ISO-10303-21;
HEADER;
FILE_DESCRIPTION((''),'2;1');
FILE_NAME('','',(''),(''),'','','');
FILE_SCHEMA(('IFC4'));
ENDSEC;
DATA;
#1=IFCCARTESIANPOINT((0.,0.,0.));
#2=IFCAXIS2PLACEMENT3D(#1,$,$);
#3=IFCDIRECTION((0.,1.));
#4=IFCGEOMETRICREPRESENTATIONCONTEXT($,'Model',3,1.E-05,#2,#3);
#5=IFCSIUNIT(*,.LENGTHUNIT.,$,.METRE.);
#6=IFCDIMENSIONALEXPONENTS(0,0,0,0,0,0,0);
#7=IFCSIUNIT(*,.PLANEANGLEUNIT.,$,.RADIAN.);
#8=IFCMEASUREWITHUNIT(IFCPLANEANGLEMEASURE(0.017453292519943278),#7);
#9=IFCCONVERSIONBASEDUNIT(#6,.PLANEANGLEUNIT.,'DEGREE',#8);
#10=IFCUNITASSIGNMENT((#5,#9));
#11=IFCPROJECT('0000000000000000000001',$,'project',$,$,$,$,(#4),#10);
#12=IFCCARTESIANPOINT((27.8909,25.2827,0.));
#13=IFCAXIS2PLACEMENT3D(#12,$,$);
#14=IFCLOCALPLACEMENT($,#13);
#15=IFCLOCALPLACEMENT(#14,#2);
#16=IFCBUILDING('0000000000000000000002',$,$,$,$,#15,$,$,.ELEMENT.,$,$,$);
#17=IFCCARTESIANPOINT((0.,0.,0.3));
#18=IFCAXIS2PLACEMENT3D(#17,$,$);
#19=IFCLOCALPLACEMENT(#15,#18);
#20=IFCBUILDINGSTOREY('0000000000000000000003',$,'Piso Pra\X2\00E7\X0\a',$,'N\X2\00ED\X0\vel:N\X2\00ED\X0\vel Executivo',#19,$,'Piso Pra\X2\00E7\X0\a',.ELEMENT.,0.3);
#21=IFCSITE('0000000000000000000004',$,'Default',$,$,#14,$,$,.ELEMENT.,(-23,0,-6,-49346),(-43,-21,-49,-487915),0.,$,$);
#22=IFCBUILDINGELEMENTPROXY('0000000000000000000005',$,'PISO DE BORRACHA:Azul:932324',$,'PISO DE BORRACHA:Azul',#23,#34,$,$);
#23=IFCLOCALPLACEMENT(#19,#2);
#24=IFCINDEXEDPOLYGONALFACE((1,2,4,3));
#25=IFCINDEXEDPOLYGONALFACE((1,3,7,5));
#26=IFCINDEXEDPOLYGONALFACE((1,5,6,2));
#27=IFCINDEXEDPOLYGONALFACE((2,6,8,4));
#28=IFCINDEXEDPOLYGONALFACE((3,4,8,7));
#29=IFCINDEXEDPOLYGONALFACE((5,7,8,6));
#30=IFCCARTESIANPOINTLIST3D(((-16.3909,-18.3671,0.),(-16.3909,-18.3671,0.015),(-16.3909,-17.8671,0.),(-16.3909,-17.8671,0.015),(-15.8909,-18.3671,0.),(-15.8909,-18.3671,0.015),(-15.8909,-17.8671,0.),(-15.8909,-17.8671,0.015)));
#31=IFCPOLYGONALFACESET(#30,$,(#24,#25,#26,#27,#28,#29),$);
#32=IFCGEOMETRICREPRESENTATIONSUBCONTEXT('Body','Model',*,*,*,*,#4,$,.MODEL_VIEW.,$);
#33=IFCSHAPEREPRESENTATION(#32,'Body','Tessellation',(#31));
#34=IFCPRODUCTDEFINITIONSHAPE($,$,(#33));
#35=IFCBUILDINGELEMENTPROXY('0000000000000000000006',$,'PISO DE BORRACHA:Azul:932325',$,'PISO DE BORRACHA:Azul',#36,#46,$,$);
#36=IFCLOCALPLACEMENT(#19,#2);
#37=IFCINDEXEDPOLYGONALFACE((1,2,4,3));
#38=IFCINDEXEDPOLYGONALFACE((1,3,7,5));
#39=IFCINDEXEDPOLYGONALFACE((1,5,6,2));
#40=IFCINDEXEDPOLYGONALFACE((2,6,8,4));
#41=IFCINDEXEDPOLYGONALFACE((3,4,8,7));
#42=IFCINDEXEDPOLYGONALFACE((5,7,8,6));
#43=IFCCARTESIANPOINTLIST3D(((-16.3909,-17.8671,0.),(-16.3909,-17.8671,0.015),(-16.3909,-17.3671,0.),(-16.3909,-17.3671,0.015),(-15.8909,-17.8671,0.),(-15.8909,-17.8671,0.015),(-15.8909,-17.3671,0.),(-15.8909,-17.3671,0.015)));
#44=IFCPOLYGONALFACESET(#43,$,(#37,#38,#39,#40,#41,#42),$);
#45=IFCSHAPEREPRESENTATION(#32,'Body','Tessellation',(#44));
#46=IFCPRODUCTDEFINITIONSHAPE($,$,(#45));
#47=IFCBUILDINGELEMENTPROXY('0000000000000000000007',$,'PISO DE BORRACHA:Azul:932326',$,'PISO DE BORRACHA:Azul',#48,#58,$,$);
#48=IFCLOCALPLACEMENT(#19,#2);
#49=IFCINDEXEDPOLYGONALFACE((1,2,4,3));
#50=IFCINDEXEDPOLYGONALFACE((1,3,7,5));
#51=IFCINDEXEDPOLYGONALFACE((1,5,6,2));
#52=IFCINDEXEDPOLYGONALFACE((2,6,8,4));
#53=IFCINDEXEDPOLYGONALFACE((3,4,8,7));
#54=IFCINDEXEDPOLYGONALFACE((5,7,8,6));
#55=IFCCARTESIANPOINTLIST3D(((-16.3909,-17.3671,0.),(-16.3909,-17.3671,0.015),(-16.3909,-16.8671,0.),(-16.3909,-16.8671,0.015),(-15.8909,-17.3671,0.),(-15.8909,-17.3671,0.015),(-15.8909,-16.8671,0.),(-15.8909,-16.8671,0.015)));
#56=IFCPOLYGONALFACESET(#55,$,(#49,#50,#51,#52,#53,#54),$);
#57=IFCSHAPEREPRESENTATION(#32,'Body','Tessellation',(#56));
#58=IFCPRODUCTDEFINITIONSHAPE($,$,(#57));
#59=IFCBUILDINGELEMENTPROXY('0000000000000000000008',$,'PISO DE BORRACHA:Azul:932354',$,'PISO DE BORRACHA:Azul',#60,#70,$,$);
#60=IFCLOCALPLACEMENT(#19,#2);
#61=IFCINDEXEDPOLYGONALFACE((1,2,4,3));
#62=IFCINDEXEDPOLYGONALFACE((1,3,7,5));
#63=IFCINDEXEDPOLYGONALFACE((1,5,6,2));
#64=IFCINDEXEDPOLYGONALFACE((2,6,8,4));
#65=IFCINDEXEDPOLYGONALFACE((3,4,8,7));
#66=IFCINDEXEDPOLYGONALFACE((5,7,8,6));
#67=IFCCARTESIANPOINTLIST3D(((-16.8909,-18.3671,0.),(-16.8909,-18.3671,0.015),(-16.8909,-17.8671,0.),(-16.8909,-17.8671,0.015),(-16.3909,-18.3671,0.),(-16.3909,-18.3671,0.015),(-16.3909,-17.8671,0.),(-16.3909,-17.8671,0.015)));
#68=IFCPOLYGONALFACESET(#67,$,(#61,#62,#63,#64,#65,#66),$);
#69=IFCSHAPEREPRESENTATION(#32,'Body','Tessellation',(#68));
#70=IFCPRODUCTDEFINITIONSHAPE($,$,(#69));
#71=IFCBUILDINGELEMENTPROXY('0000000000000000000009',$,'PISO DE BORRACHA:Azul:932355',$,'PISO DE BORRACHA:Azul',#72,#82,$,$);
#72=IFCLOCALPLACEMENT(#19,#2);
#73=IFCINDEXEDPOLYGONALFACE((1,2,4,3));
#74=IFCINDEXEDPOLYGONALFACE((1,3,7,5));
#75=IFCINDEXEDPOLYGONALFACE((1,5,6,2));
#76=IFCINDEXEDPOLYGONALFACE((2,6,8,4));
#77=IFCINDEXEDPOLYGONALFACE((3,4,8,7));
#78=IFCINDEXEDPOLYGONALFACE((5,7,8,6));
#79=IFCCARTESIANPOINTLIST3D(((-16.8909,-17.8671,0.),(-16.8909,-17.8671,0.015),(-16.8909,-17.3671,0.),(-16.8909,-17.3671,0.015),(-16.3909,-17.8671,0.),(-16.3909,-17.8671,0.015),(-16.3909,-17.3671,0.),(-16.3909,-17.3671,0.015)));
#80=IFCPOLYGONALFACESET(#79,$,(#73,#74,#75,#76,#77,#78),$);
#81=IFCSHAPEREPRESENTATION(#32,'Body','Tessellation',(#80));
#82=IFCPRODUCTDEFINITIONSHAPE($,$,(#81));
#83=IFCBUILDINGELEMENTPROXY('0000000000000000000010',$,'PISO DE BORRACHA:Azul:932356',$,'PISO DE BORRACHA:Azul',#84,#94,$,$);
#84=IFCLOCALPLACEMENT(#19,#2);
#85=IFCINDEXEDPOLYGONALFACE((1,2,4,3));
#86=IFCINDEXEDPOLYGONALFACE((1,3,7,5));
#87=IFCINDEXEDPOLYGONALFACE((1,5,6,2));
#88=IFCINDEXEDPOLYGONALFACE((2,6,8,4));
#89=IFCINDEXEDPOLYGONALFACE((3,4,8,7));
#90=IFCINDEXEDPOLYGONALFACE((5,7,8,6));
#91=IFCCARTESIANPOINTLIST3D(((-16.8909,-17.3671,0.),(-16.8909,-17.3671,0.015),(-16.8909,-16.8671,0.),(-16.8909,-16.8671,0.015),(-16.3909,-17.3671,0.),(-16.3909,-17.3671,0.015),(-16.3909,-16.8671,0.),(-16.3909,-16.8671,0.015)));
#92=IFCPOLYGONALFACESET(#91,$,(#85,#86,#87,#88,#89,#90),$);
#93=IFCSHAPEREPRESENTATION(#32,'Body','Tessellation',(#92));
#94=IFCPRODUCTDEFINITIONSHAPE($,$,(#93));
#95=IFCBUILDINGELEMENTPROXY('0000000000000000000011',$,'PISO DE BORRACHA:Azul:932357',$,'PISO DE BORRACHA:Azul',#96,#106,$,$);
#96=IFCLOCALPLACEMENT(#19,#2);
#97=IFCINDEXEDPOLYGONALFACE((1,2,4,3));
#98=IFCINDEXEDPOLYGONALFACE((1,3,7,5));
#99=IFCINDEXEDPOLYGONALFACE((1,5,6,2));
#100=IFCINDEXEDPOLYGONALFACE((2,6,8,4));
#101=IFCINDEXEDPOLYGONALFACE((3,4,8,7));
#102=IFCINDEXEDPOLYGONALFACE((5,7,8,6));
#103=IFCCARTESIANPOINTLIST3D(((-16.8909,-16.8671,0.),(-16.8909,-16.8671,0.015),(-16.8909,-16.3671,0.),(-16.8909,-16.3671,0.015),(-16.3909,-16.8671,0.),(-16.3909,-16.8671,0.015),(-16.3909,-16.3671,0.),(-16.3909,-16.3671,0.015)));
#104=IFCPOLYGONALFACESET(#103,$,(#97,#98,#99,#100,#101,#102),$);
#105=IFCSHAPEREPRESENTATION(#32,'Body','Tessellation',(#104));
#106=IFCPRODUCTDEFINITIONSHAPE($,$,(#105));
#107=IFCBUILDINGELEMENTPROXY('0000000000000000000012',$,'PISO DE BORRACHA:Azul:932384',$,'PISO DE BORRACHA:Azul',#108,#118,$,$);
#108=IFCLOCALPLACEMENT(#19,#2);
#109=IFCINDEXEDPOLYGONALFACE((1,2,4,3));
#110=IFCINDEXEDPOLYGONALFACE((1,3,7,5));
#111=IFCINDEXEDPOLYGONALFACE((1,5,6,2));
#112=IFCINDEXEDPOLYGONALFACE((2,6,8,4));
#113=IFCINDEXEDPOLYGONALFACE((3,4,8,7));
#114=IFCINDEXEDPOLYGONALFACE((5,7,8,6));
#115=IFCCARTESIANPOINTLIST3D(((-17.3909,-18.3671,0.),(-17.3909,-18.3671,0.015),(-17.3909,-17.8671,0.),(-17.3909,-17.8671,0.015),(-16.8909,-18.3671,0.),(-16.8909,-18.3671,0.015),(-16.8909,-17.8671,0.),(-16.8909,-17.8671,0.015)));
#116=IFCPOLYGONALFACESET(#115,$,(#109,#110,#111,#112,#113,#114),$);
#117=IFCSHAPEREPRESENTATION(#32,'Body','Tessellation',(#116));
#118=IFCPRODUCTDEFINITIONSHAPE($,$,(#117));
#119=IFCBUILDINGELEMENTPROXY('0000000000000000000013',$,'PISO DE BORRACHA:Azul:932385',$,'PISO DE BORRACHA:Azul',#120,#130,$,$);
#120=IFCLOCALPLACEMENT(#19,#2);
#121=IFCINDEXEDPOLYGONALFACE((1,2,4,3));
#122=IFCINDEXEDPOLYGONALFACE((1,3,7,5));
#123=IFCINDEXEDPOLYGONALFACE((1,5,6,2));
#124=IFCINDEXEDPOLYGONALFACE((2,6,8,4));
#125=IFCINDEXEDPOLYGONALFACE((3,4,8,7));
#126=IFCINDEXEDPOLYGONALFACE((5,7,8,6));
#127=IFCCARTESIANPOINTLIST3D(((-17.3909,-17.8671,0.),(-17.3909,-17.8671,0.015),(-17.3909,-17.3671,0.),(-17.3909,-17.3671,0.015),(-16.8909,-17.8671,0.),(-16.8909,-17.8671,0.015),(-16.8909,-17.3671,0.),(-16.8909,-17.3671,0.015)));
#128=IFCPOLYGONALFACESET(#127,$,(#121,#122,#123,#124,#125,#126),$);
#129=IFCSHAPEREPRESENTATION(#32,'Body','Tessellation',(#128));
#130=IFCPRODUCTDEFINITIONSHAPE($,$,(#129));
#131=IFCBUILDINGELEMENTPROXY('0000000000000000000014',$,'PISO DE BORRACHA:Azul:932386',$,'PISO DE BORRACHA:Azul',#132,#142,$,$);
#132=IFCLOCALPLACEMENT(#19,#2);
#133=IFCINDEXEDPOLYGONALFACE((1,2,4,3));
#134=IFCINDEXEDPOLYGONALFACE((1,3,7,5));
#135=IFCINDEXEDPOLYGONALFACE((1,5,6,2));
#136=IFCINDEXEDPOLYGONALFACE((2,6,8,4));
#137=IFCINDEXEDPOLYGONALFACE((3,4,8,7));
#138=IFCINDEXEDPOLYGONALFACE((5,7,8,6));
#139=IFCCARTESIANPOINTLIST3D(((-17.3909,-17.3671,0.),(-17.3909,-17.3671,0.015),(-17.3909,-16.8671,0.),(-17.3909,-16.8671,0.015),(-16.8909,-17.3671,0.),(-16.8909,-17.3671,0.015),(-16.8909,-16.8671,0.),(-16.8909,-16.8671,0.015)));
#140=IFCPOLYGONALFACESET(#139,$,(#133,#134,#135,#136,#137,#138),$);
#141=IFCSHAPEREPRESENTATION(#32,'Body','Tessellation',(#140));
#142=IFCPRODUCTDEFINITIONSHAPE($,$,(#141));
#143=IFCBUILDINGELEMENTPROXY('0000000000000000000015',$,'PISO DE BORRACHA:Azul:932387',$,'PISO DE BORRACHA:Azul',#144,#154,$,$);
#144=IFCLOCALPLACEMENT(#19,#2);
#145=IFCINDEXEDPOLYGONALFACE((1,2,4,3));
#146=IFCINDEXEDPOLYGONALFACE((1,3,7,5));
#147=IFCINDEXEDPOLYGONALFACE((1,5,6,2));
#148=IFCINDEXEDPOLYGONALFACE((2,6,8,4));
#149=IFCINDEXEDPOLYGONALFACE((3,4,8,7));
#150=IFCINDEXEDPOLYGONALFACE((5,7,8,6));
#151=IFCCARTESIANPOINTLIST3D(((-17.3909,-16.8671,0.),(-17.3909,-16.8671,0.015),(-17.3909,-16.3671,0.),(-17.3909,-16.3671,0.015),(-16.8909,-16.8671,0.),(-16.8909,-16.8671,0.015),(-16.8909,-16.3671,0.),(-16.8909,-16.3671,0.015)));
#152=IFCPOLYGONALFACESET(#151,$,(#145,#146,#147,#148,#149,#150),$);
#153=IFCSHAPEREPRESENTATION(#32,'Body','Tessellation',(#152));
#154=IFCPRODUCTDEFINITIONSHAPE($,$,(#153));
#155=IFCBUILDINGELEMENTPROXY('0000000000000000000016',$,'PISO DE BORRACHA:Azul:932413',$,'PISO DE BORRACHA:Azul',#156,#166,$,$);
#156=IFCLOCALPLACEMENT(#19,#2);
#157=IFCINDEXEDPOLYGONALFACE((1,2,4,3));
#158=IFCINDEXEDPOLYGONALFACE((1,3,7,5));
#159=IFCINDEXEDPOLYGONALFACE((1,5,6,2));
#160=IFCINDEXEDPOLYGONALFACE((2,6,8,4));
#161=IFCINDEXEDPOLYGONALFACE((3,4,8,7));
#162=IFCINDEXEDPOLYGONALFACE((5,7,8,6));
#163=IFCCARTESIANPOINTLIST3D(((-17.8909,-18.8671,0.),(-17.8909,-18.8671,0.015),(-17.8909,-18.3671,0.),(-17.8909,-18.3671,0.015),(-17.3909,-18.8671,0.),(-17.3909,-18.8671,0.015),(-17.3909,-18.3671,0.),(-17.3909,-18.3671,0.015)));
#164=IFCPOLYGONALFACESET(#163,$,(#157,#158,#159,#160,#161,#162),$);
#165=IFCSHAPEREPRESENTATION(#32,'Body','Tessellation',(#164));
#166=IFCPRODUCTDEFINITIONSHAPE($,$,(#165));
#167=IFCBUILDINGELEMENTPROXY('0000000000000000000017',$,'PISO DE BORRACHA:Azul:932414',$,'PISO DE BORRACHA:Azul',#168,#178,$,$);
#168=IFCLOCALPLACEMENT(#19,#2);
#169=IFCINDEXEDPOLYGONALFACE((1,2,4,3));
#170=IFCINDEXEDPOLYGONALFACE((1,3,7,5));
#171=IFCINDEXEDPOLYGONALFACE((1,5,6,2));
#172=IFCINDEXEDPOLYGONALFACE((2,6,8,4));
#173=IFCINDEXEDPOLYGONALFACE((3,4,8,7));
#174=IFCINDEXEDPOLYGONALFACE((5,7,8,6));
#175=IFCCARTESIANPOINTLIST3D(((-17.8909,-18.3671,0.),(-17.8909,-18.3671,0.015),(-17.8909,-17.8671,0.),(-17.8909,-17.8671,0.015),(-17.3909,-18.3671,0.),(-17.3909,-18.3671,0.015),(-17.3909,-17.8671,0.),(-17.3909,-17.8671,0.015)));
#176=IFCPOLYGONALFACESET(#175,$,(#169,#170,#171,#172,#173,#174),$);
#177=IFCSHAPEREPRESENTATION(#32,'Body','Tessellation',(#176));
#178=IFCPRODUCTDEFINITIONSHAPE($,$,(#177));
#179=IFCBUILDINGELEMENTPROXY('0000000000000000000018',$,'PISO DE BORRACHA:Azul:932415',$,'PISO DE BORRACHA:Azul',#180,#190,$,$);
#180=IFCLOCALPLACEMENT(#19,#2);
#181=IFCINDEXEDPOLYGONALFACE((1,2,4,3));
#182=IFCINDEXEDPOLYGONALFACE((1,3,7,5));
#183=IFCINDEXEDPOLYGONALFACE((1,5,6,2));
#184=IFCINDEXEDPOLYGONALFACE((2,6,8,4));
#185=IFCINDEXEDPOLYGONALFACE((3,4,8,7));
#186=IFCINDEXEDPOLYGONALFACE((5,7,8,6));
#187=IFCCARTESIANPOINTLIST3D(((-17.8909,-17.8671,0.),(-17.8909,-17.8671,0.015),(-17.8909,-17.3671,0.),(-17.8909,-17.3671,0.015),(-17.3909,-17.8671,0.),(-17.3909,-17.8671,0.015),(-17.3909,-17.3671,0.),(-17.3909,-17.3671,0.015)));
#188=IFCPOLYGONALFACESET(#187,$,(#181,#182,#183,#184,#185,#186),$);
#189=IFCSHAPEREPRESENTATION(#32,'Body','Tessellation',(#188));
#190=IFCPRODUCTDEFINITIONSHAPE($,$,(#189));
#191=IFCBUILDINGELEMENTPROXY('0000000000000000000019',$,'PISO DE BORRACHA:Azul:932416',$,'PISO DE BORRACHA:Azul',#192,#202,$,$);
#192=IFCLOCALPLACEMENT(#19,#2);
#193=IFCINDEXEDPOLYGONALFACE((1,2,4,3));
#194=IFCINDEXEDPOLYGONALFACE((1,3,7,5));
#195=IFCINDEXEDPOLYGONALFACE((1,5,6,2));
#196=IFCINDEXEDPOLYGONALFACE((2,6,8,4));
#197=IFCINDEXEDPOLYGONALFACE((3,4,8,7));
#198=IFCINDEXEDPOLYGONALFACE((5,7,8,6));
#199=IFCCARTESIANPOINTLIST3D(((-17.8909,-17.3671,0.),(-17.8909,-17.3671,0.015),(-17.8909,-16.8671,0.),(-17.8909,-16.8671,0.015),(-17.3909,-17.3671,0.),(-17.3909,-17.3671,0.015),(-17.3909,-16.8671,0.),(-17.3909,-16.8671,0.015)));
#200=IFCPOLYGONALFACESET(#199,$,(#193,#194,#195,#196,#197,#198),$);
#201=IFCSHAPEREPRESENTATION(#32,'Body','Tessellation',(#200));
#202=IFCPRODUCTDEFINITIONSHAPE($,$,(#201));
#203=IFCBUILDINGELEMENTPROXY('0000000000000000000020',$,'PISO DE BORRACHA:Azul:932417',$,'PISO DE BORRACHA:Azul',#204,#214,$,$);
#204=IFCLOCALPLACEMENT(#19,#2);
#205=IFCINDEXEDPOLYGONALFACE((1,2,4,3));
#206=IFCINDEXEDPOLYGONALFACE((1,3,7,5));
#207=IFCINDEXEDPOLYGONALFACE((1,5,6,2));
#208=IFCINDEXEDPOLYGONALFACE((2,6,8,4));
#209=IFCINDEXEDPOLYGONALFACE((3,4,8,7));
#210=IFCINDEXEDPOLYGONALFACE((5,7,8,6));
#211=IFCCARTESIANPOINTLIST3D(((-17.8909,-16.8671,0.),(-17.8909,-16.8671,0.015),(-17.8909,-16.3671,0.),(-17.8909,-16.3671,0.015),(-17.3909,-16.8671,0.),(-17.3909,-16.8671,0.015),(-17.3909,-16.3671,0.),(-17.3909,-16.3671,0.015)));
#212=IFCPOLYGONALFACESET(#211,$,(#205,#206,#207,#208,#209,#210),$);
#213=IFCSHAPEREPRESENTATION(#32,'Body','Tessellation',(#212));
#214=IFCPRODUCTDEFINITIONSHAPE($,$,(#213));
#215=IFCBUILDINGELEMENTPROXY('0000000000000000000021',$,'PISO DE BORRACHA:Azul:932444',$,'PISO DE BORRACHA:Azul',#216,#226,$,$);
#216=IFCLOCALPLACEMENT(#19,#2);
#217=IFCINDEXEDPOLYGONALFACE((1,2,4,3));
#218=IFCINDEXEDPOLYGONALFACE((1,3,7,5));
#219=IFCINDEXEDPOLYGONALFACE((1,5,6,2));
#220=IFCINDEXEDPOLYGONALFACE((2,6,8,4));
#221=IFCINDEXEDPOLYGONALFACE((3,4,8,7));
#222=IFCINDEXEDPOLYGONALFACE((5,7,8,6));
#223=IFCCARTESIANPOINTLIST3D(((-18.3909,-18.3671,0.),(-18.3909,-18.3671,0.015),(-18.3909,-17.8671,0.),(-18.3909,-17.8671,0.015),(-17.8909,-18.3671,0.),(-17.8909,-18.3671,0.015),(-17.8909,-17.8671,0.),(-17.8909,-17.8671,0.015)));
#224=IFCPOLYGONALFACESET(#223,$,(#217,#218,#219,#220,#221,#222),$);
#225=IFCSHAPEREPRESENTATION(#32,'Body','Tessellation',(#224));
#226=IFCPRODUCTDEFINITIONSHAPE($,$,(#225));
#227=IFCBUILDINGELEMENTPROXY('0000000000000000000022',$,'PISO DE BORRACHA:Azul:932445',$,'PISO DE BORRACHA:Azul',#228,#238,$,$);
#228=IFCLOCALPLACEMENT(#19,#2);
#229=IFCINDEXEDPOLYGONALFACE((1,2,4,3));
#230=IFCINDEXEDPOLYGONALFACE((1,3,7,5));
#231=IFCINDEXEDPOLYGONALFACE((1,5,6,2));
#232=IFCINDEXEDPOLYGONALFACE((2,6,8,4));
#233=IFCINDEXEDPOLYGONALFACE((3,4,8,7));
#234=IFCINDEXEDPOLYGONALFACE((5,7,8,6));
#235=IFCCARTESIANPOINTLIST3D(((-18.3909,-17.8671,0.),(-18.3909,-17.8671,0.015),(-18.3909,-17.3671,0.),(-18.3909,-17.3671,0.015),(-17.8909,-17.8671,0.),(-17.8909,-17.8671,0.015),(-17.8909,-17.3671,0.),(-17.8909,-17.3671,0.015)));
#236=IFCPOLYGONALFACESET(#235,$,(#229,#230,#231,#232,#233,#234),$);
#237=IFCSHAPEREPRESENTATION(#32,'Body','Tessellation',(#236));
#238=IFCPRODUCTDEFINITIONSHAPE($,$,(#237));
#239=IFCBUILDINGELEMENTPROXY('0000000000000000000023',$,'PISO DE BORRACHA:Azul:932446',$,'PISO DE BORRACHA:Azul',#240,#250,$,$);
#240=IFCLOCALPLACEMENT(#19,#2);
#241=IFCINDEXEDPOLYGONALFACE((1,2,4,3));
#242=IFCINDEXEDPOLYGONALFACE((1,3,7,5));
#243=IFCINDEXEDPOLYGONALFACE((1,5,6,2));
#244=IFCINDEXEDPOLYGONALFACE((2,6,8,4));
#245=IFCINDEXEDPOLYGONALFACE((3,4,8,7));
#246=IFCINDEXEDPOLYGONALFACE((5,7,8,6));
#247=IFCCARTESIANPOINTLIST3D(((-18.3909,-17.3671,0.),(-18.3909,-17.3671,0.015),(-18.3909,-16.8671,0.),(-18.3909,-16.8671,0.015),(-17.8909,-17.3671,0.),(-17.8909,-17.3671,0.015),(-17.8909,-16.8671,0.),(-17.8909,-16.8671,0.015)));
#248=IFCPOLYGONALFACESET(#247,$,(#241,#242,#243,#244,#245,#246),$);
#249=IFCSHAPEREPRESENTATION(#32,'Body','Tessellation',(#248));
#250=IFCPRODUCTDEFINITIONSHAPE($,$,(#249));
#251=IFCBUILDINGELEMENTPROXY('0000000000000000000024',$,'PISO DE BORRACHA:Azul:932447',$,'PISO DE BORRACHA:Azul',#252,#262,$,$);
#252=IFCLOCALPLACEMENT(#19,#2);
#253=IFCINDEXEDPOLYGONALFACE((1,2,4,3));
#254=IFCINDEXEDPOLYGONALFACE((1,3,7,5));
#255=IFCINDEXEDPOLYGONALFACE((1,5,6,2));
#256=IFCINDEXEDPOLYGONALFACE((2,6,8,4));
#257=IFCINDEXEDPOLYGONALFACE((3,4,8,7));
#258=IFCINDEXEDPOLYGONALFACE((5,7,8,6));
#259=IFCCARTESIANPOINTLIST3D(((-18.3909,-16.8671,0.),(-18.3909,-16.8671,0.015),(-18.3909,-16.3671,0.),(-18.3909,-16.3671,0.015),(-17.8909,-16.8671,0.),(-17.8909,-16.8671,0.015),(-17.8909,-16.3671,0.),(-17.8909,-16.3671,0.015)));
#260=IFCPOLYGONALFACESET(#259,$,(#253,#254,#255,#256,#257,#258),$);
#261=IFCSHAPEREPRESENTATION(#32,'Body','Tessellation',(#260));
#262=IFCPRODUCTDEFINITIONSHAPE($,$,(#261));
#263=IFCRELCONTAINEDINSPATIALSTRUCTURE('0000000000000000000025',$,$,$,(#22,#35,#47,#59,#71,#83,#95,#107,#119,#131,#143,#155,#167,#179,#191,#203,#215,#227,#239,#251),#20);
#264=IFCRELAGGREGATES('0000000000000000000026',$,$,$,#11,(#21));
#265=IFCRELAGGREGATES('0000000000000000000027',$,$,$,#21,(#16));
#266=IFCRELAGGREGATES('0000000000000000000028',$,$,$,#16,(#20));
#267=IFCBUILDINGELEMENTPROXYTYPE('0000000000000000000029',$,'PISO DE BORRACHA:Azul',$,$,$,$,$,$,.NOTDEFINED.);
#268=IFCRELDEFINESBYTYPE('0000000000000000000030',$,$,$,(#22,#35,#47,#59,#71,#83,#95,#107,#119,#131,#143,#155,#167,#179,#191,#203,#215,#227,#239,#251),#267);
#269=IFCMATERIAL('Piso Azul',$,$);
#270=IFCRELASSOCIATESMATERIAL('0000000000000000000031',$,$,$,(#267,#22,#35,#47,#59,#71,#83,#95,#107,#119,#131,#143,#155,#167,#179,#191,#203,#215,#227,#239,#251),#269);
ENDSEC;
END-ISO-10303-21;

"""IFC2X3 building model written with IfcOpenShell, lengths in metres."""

from ifc_helpers import new_model, entity, si_unit, converted_unit, direction, frame, origin, origin_2d_with_axis, place, context, subcontext, project, spatial, rectangle, extrude, source, transform, mapped, material, type_object, type_shapes, element, save


model = new_model("IFC2X3")

# Units and contexts
model_context = context("Model", 3, precision=1e-05, world=origin(), true_north=direction((0.0, 1.0)))
body_context = subcontext(model_context, "Body", "Model", "MODEL_VIEW")
ifc_project = project(units=[si_unit("LENGTHUNIT", "METRE"), converted_unit("PLANEANGLEUNIT", "DEGREE", entity("IfcPlaneAngleMeasure", 0.017453292519943278), si_unit("PLANEANGLEUNIT", "RADIAN"), dimensions=[0, 0, 0, 0, 0, 0, 0])], contexts=[model_context])

# Site, building, storey
site_placement = place(None, frame((27.8909, 25.2827, 0.0)))
site = spatial("IfcSite", under=ifc_project, at=site_placement, Name="Default", CompositionType="ELEMENT", RefLatitude=(-23, 0, -6, -49346), RefLongitude=(-43, -21, -49, -487915), RefElevation=0.0)
building_placement = place(site_placement, origin())
building = spatial("IfcBuilding", under=site, at=building_placement, CompositionType="ELEMENT")
storey_placement = place(building_placement, frame((0.0, 0.0, 0.3)))
storey = spatial("IfcBuildingStorey", under=building, at=storey_placement, Name="Piso Praça", ObjectType="Nível:Nível Executivo", LongName="Piso Praça", CompositionType="ELEMENT", Elevation=0.3)

# Building element proxies
ifc_material_1 = material(Name="Piso Azul")
building_element_proxy_type_1 = type_object("IfcBuildingElementProxyType", Name="PISO DE BORRACHA:Azul", PredefinedType="NOTDEFINED", material=ifc_material_1)
shared_shape_1 = source(origin(), body_context, "Body", "SweptSolid", [
    extrude(rectangle(XDim=0.5, YDim=0.5, at=origin_2d_with_axis()), frame((0.25, 0.25, 0.0), z_axis=(0.0, 0.0, 1.0), x_axis=(-1.0, 0.0, 0.0)), (0.0, 0.0, 1.0), 0.015),
])
type_shapes(building_element_proxy_type_1, [shared_shape_1])
for number, where, z_axis, x_axis, name in (
    (1, (-16.3909, -17.8671, 0.0), (0.0, 0.0, 1.0), (0.0, -1.0, 0.0), "PISO DE BORRACHA:Azul:932324"),
    (2, (-16.3909, -17.3671, 0.0), (0.0, 0.0, 1.0), (0.0, -1.0, 0.0), "PISO DE BORRACHA:Azul:932325"),
    (3, (-16.3909, -16.8671, 0.0), (0.0, 0.0, 1.0), (0.0, -1.0, 0.0), "PISO DE BORRACHA:Azul:932326"),
    (4, (-16.8909, -17.8671, 0.0), (0.0, 0.0, 1.0), (0.0, -1.0, 0.0), "PISO DE BORRACHA:Azul:932354"),
    (5, (-16.8909, -17.3671, 0.0), (0.0, 0.0, 1.0), (0.0, -1.0, 0.0), "PISO DE BORRACHA:Azul:932355"),
    (6, (-16.8909, -16.8671, 0.0), (0.0, 0.0, 1.0), (0.0, -1.0, 0.0), "PISO DE BORRACHA:Azul:932356"),
    (7, (-16.8909, -16.3671, 0.0), (0.0, 0.0, 1.0), (0.0, -1.0, 0.0), "PISO DE BORRACHA:Azul:932357"),
    (8, (-17.3909, -17.8671, 0.0), (0.0, 0.0, 1.0), (0.0, -1.0, 0.0), "PISO DE BORRACHA:Azul:932384"),
    (9, (-17.3909, -17.3671, 0.0), (0.0, 0.0, 1.0), (0.0, -1.0, 0.0), "PISO DE BORRACHA:Azul:932385"),
    (10, (-17.3909, -16.8671, 0.0), (0.0, 0.0, 1.0), (0.0, -1.0, 0.0), "PISO DE BORRACHA:Azul:932386"),
    (11, (-17.3909, -16.3671, 0.0), (0.0, 0.0, 1.0), (0.0, -1.0, 0.0), "PISO DE BORRACHA:Azul:932387"),
    (12, (-17.8909, -18.3671, 0.0), (0.0, 0.0, 1.0), (0.0, -1.0, 0.0), "PISO DE BORRACHA:Azul:932413"),
    (13, (-17.8909, -17.8671, 0.0), (0.0, 0.0, 1.0), (0.0, -1.0, 0.0), "PISO DE BORRACHA:Azul:932414"),
    (14, (-17.8909, -17.3671, 0.0), (0.0, 0.0, 1.0), (0.0, -1.0, 0.0), "PISO DE BORRACHA:Azul:932415"),
    (15, (-17.8909, -16.8671, 0.0), (0.0, 0.0, 1.0), (0.0, -1.0, 0.0), "PISO DE BORRACHA:Azul:932416"),
    (16, (-17.8909, -16.3671, 0.0), (0.0, 0.0, 1.0), (0.0, -1.0, 0.0), "PISO DE BORRACHA:Azul:932417"),
    (17, (-18.3909, -17.8671, 0.0), (0.0, 0.0, 1.0), (0.0, -1.0, 0.0), "PISO DE BORRACHA:Azul:932444"),
    (18, (-18.3909, -17.3671, 0.0), (0.0, 0.0, 1.0), (0.0, -1.0, 0.0), "PISO DE BORRACHA:Azul:932445"),
    (19, (-18.3909, -16.8671, 0.0), (0.0, 0.0, 1.0), (0.0, -1.0, 0.0), "PISO DE BORRACHA:Azul:932446"),
    (20, (-18.3909, -16.3671, 0.0), (0.0, 0.0, 1.0), (0.0, -1.0, 0.0), "PISO DE BORRACHA:Azul:932447"),
):
    element("IfcBuildingElementProxy", number, at=place(storey_placement, frame(where, z_axis=z_axis, x_axis=x_axis)), inside=storey, type_object=building_element_proxy_type_1, material=ifc_material_1, Name=name, ObjectType="PISO DE BORRACHA:Azul", context=body_context, shape_type="MappedRepresentation", body=[
        mapped(shared_shape_1, transform((0.0, 0.0, 0.0), scale=1.0)),
    ])

save(model, "model.ifc")
